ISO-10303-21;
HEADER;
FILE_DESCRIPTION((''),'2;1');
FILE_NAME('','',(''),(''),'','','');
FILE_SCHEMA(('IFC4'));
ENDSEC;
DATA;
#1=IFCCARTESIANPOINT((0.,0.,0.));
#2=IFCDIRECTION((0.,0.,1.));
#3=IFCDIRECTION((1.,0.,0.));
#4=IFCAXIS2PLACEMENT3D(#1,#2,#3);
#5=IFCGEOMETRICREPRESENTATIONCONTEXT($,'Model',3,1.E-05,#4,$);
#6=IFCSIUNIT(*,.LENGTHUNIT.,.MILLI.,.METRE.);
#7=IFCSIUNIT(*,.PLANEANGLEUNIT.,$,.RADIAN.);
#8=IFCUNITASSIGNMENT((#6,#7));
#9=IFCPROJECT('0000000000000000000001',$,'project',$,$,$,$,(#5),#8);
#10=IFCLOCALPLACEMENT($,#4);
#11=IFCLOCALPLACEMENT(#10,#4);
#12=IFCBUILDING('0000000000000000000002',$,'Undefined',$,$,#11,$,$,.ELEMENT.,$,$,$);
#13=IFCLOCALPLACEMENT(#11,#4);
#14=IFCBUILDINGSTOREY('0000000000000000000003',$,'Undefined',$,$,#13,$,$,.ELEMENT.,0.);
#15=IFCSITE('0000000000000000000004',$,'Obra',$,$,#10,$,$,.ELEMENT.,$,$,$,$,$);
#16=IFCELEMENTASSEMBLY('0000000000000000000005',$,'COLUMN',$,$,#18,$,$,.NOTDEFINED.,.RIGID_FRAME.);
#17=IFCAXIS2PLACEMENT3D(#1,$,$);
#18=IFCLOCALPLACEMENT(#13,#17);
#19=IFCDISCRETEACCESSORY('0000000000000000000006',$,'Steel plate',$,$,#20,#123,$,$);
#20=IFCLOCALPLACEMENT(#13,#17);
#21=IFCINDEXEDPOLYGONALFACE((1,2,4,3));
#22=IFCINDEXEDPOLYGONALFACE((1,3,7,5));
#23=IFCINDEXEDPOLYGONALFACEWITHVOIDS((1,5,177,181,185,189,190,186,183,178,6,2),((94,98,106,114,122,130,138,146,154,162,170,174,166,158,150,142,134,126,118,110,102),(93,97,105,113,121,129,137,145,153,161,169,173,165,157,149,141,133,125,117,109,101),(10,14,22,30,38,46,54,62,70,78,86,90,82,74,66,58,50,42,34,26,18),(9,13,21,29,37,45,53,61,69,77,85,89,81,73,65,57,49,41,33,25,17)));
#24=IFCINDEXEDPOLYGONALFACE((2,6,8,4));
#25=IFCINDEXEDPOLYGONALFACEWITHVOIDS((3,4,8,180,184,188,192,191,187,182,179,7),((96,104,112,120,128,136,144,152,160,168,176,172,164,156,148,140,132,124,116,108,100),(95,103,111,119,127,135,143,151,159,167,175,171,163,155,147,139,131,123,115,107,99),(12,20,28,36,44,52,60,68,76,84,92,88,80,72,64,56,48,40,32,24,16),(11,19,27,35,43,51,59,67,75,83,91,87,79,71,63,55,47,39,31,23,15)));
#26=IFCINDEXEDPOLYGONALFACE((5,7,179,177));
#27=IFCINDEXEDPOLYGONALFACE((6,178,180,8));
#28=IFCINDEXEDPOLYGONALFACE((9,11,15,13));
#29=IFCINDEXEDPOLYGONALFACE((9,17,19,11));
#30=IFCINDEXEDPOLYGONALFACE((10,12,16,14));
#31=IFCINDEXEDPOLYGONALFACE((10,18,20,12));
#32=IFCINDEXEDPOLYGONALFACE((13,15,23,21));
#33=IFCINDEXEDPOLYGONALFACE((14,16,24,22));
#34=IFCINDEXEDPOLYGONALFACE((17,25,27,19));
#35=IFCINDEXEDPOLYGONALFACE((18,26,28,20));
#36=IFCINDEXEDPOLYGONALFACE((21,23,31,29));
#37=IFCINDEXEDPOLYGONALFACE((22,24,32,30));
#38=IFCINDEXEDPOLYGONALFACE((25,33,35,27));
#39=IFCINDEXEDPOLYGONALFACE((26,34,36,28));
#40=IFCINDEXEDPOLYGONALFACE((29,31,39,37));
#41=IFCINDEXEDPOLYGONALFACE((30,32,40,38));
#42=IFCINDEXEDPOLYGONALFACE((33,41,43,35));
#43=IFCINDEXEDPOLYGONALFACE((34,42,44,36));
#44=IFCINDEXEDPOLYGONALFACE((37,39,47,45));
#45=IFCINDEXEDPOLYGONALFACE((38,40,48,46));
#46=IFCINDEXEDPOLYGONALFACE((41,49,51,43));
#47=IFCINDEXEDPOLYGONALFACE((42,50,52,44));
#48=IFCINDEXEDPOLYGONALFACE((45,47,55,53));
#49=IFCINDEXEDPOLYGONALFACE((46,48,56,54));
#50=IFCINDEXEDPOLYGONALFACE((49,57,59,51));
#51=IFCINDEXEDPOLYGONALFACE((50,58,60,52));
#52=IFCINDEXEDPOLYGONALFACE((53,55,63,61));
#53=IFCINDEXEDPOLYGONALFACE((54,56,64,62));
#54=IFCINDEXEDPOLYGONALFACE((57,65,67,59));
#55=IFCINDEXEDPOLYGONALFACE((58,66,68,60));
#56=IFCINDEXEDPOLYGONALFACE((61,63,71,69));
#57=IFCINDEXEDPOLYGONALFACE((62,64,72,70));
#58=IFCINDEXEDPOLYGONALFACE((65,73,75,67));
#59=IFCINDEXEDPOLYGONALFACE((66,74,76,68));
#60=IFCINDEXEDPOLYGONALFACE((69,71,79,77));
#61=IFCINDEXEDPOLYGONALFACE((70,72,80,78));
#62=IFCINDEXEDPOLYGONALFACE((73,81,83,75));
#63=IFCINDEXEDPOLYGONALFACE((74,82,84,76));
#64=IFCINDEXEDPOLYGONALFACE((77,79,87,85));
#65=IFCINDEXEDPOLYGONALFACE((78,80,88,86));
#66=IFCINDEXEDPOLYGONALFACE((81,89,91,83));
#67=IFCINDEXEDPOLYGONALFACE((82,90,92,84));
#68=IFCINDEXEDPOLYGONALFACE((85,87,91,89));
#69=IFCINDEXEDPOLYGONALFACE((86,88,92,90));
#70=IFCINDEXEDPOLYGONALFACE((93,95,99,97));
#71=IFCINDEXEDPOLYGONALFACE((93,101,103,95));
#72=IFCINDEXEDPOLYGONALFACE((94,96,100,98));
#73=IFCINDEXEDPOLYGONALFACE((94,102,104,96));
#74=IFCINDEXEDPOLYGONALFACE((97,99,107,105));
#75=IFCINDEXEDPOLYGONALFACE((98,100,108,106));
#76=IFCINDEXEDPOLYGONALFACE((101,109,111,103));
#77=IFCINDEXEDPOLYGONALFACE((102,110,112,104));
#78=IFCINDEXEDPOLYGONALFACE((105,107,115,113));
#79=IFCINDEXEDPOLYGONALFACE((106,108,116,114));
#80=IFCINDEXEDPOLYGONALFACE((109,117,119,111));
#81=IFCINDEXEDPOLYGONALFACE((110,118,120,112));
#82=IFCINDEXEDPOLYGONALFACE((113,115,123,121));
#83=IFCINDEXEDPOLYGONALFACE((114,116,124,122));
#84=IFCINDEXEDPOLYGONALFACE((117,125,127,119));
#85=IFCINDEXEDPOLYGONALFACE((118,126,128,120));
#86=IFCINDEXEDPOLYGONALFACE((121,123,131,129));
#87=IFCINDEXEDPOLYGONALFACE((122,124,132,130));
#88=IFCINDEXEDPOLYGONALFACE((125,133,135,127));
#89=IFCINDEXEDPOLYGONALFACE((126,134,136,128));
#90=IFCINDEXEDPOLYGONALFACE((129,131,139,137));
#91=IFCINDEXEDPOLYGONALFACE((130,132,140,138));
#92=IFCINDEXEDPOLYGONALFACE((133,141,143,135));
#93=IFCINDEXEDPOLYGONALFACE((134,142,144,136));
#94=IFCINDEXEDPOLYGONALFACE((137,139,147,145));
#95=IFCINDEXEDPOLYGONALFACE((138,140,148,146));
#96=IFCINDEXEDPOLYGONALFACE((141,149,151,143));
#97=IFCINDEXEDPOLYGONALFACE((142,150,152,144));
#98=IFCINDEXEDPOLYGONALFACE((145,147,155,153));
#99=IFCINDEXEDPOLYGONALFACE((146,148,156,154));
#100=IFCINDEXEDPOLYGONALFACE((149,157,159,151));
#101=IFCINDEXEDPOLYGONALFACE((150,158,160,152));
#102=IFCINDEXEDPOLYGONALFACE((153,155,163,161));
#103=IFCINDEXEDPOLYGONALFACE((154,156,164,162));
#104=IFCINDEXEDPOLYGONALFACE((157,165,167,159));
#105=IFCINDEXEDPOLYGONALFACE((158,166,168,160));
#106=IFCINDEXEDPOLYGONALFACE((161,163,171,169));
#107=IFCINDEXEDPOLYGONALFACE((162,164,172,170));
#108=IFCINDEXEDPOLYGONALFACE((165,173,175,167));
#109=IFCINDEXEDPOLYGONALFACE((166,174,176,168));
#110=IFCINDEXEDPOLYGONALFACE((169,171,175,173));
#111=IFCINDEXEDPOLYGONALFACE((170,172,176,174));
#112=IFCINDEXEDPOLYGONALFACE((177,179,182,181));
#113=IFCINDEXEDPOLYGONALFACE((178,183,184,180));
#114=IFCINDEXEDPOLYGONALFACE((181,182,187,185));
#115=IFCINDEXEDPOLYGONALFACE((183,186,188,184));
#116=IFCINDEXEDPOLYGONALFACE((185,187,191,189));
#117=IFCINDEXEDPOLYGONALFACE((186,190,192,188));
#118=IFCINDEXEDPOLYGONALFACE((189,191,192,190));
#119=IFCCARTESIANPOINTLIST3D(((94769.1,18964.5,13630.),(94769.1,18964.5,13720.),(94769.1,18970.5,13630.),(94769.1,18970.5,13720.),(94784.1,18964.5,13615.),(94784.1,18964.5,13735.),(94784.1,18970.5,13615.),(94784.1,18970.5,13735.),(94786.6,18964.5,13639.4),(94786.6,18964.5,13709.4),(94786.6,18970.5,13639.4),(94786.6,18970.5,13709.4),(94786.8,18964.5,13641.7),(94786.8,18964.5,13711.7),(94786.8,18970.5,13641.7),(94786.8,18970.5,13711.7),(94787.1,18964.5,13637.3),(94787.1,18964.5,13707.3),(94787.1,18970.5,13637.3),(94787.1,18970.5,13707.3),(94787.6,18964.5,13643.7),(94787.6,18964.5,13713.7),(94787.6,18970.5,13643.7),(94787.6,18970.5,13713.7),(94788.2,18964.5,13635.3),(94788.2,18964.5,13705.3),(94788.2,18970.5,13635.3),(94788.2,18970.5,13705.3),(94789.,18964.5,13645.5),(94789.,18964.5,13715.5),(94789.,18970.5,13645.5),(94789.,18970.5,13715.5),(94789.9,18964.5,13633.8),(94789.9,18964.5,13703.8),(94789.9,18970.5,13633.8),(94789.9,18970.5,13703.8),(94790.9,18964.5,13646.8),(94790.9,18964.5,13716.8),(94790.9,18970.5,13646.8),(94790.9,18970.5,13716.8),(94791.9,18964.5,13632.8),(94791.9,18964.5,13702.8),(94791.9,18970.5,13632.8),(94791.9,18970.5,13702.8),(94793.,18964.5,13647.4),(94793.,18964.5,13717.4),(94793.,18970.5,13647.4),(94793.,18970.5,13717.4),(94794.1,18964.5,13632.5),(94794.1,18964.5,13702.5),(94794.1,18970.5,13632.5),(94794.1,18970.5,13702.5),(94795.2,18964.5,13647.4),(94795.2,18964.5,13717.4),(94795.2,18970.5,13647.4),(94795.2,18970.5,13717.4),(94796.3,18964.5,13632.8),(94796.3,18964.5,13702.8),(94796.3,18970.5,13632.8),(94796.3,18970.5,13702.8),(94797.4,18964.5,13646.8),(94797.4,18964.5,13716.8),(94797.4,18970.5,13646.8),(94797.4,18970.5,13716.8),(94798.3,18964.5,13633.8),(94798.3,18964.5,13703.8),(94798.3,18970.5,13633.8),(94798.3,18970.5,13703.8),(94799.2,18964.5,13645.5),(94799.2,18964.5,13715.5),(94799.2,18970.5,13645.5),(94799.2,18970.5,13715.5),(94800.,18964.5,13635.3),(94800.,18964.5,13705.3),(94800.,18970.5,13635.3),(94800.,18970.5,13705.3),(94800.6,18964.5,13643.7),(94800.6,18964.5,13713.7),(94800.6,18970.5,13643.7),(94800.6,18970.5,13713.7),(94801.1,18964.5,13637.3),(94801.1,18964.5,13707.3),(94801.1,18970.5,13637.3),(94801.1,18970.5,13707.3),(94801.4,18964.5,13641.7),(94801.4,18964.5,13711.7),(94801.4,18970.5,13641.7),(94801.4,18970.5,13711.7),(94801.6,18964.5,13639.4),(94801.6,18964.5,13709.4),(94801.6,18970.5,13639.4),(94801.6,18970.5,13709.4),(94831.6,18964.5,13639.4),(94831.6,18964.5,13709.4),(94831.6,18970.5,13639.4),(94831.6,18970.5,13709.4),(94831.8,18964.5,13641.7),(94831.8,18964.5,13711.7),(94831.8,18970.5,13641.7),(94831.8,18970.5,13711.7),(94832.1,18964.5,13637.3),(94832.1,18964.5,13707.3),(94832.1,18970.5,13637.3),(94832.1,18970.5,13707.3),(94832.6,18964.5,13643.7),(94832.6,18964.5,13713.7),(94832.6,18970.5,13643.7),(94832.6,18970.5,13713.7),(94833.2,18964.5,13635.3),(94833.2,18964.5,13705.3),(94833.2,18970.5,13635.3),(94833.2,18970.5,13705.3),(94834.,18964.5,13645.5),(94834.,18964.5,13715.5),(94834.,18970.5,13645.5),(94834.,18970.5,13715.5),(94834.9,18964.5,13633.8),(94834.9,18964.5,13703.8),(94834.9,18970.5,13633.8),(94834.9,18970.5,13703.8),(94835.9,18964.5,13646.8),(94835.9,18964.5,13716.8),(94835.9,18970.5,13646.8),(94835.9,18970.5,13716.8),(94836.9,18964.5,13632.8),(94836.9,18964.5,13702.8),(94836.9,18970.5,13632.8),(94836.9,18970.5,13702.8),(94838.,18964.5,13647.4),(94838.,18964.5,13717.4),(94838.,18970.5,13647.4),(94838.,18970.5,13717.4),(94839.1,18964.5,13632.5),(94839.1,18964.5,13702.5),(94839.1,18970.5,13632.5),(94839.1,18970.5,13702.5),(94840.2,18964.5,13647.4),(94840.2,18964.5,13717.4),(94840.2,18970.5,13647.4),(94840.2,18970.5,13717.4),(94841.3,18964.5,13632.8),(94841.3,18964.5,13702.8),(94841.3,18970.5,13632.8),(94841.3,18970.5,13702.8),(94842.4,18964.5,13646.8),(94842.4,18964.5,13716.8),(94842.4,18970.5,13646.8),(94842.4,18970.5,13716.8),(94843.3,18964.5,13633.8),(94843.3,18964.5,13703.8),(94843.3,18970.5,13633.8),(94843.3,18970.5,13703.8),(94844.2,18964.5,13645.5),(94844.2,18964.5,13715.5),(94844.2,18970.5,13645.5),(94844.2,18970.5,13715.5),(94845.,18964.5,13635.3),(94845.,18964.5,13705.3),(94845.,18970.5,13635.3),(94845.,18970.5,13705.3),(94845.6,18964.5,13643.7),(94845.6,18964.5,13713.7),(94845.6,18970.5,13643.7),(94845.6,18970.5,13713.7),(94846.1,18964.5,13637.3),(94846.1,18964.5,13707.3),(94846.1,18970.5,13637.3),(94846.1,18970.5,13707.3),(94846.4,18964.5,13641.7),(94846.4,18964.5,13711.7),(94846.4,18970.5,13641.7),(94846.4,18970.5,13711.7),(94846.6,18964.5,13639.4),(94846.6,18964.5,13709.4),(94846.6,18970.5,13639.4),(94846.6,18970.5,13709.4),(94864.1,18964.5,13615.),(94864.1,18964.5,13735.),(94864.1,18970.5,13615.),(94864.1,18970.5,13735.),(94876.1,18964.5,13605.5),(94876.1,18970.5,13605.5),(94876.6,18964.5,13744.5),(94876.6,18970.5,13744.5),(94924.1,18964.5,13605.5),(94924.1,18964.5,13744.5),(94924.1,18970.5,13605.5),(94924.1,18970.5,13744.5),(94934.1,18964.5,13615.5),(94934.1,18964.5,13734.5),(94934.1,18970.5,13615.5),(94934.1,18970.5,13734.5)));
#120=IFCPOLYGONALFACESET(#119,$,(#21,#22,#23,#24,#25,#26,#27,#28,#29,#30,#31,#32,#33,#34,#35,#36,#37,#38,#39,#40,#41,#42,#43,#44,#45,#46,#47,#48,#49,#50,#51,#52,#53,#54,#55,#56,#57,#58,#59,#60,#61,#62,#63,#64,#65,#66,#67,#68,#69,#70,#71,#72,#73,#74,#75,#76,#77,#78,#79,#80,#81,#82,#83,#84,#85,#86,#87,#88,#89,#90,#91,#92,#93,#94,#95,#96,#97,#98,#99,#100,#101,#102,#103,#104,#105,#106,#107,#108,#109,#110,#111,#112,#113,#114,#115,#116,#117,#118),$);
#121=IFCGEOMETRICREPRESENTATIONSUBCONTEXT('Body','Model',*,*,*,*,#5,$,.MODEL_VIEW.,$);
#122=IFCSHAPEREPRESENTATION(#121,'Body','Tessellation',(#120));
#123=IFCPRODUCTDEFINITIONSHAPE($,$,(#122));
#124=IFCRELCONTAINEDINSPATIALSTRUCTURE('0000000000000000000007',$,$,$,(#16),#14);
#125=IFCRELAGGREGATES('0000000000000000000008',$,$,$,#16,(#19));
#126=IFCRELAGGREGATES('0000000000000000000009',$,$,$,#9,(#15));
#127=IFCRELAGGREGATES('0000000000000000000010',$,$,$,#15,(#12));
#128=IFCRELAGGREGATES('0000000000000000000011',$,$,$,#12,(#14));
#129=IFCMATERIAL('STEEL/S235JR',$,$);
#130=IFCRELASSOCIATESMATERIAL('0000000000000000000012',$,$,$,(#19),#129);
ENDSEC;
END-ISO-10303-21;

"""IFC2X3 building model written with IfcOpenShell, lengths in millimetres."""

from ifc_helpers import new_model, si_unit, frame, origin_with_axes, origin_2d_with_axis, place, context, subcontext, project, spatial, polyline, circle, outline, extrude, source, transform, mapped, material, element, aggregate, save


model = new_model("IFC2X3")

# Units and contexts
model_context = context("Model", 3, precision=1e-05, world=origin_with_axes())
body_context = subcontext(model_context, "Body", "Model", "MODEL_VIEW")
ifc_project = project(units=[si_unit("LENGTHUNIT", "METRE", prefix="MILLI"), si_unit("PLANEANGLEUNIT", "RADIAN")], contexts=[model_context])

# Site, building, storey
site_placement = place(None, origin_with_axes())
site = spatial("IfcSite", under=ifc_project, at=site_placement, Name="Obra", CompositionType="ELEMENT")
building_placement = place(site_placement, origin_with_axes())
building = spatial("IfcBuilding", under=site, at=building_placement, Name="Undefined", CompositionType="ELEMENT")
storey_placement = place(building_placement, origin_with_axes())
storey = spatial("IfcBuildingStorey", under=building, at=storey_placement, Name="Undefined", CompositionType="ELEMENT", Elevation=0.0)

# Shared definitions
ifc_material_1 = material(Name="STEEL/S235JR")

# Element assembly, discrete accessory, opening
assembly_1_placement = place(storey_placement, origin_with_axes())
assembly_1 = element("IfcElementAssembly", 1, at=assembly_1_placement, inside=storey, Name="COLUMN", AssemblyPlace="NOTDEFINED", PredefinedType="RIGID_FRAME")
shared_shape_1 = source(origin_with_axes(), body_context, "Body", "SweptSolid", [
    extrude(circle(Radius=7.5, at=origin_2d_with_axis()), frame((0.0, 2.4, 0.0), z_axis=(0.0, 1.0, 0.0), x_axis=(1.0, 0.0, 0.0)), (0.0, 0.0, 1.0), 6.2),
])
discrete_accessory_1_placement = place(assembly_1_placement, frame((94934.1, 18967.5, 13615.5), z_axis=(0.0, 1.0, 0.0), x_axis=(-0.707107, 0.0, -0.707107)))
discrete_accessory_1 = element("IfcDiscreteAccessory", 2, at=discrete_accessory_1_placement, material=ifc_material_1, Name="Steel plate", context=body_context, shape_type="SweptSolid", body=[
    extrude(outline(polyline([(0.0, 0.0), (14.1, 0.0), (48.1, 33.9), (49.9, 49.1), (106.4, 105.7), (106.4, 126.9), (42.8, 190.6), (21.6, 190.6), (-35.0, 134.0), (-50.6, 131.9), (-84.1, 98.3), (-84.1, 84.1), (0.0, 0.0)])), frame((0.0, 0.0, -3.0), z_axis=(0.0, 0.0, 1.0), x_axis=(1.0, 0.0, 0.0)), (0.0, 0.0, 1.0), 6.0),
])
opening_1_placement = place(assembly_1_placement, frame((94816.6, 18973.0, 13710.0), z_axis=(-1.0, 0.0, 0.0), x_axis=(0.0, 0.0, -1.0)))
element("IfcOpeningElement", 3, at=opening_1_placement, cuts=discrete_accessory_1, ObjectType="Opening", context=body_context, shape_type="MappedRepresentation", body=[
    mapped(shared_shape_1, transform((0.0, 0.0, -22.5))),
    mapped(shared_shape_1, transform((70.0, 0.0, -22.5))),
    mapped(shared_shape_1, transform((0.0, 0.0, 22.5))),
    mapped(shared_shape_1, transform((70.0, 0.0, 22.5))),
])
aggregate(assembly_1, [discrete_accessory_1])

save(model, "model.ifc")
